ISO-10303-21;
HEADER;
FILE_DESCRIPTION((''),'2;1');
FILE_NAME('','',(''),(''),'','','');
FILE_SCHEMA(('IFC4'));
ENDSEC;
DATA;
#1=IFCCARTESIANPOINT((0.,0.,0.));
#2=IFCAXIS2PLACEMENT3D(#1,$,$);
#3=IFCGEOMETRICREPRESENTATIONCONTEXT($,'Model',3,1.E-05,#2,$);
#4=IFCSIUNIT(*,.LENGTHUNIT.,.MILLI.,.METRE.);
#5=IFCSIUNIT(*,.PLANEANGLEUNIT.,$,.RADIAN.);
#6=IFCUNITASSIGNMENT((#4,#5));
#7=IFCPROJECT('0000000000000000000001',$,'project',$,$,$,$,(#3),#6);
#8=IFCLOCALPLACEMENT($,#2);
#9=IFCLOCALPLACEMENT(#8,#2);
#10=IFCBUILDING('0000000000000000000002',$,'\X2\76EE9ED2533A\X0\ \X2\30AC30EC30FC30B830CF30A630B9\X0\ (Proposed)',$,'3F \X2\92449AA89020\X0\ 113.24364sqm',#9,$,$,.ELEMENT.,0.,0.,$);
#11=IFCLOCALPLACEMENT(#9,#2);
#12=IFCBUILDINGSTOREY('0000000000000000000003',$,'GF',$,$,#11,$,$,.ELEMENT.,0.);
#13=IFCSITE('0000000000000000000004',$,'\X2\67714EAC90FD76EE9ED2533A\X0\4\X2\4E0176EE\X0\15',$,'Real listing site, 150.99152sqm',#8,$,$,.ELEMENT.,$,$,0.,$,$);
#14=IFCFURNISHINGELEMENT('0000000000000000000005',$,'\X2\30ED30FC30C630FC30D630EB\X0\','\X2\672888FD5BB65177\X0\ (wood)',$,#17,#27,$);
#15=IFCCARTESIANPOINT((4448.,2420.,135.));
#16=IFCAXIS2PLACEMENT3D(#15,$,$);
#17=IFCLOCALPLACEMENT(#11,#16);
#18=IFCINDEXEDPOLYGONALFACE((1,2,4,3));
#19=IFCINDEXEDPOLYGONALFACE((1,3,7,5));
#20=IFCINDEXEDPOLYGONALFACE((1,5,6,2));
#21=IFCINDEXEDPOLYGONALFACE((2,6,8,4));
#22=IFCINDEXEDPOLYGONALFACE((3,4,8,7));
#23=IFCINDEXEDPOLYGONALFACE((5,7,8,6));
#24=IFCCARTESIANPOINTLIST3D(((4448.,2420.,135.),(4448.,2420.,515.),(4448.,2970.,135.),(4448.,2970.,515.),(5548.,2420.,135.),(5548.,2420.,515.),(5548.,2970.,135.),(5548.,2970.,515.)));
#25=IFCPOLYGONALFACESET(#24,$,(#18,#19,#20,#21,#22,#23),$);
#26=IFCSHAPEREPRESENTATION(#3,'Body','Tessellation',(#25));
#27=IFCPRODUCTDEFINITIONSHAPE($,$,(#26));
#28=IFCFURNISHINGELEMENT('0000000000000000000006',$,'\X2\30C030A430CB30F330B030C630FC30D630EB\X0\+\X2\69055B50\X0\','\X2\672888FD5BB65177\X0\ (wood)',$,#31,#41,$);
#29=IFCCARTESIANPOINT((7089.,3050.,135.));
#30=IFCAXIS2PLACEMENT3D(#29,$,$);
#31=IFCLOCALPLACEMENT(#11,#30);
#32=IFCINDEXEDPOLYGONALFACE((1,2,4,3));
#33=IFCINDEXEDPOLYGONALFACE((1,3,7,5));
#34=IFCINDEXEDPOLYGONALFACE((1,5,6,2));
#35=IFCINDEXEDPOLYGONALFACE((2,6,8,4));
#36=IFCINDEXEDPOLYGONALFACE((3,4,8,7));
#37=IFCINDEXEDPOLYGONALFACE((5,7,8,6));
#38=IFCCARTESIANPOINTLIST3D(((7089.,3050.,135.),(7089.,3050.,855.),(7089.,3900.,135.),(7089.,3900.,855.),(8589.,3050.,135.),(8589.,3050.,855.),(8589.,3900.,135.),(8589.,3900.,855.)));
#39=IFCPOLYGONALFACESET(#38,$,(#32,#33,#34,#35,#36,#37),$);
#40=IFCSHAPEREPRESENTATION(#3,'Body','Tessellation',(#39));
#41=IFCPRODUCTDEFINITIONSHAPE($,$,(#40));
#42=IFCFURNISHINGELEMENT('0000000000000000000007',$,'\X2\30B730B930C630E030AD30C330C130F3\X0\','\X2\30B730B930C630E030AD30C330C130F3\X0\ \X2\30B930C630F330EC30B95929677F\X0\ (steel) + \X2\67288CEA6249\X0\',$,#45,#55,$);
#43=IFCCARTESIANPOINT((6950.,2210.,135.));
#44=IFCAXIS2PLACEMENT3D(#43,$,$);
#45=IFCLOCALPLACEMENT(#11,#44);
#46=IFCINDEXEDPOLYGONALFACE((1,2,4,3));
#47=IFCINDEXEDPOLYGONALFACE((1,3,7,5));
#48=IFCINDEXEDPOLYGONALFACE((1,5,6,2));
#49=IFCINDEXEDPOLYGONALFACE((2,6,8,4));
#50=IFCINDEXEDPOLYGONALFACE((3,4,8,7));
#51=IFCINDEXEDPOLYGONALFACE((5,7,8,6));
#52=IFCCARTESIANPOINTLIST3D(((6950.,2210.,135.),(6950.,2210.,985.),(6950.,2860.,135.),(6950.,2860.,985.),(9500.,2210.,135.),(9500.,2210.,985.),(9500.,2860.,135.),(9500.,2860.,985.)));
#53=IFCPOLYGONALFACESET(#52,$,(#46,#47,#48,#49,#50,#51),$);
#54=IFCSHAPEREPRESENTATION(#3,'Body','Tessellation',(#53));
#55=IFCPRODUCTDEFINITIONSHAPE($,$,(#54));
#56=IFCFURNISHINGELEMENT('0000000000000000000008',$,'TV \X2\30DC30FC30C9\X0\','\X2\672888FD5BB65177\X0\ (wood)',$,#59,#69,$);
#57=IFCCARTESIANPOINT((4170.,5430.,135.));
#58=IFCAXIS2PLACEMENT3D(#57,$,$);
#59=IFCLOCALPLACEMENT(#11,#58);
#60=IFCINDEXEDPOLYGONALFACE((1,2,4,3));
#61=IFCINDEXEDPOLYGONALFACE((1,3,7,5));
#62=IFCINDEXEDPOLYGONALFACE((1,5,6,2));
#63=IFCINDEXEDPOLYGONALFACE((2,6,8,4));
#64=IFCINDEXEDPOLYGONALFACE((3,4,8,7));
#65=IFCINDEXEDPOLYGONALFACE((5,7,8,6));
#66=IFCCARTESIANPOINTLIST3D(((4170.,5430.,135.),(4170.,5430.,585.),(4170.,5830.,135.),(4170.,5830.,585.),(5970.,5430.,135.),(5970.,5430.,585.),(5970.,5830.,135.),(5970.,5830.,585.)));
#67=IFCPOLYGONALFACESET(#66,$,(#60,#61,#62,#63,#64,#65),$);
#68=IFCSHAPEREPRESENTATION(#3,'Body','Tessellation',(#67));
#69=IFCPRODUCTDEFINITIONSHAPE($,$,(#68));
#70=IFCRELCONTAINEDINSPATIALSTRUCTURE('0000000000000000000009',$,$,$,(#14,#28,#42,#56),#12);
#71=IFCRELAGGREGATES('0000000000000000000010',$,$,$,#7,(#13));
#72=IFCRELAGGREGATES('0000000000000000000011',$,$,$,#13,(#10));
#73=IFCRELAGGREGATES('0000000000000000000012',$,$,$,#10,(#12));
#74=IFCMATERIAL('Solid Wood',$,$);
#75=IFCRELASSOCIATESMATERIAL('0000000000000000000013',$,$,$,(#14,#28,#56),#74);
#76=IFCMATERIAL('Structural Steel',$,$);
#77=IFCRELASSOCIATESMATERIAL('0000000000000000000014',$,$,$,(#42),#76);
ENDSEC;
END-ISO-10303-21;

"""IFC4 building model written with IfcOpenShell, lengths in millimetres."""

from ifc_helpers import new_model, si_unit, frame, frame_2d, origin, place, context, project, spatial, rectangle, extrude, material, element, save


model = new_model("IFC4")

# Units and contexts
model_context = context("Model", 3, precision=1e-05, world=origin())
ifc_project = project(units=[si_unit("LENGTHUNIT", "METRE", prefix="MILLI"), si_unit("PLANEANGLEUNIT", "RADIAN")], contexts=[model_context])

# Site, building, storey
site_placement = place(None, origin())
site = spatial("IfcSite", under=ifc_project, at=site_placement, Name="東京都目黒区4丁目15", ObjectType="Real listing site, 150.99152sqm", CompositionType="ELEMENT", RefElevation=0.0)
building_placement = place(site_placement, origin())
building = spatial("IfcBuilding", under=site, at=building_placement, Name="目黒区 ガレージハウス (Proposed)", ObjectType="3F 鉄骨造 113.24364sqm", CompositionType="ELEMENT", ElevationOfRefHeight=0.0, ElevationOfTerrain=0.0)
storey_placement = place(building_placement, origin())
storey = spatial("IfcBuildingStorey", under=building, at=storey_placement, Name="GF", CompositionType="ELEMENT", Elevation=0.0)

# Shared definitions
ifc_material_1 = material(Name="Solid Wood")

# Furnishing elements
furnishing_1_placement = place(storey_placement, frame((4448.0, 2420.0, 135.0)))
element("IfcFurnishingElement", 1, at=furnishing_1_placement, inside=storey, material=ifc_material_1, Name="ローテーブル", Description="木製家具 (wood)", context=model_context, shape_type="SweptSolid", body=[
    extrude(rectangle(XDim=1100.0, YDim=550.0, at=frame_2d((550.0, 275.0))), frame((4448.0, 2420.0, 135.0)), (0.0, 0.0, 1.0), 380.0),
])
furnishing_2_placement = place(storey_placement, frame((7089.0, 3050.0, 135.0)))
element("IfcFurnishingElement", 2, at=furnishing_2_placement, inside=storey, material=ifc_material_1, Name="ダイニングテーブル+椅子", Description="木製家具 (wood)", context=model_context, shape_type="SweptSolid", body=[
    extrude(rectangle(XDim=1500.0, YDim=850.0, at=frame_2d((750.0, 425.0))), frame((7089.0, 3050.0, 135.0)), (0.0, 0.0, 1.0), 720.0),
])
ifc_material_2 = material(Name="Structural Steel")
furnishing_3_placement = place(storey_placement, frame((6950.0, 2210.0, 135.0)))
element("IfcFurnishingElement", 3, at=furnishing_3_placement, inside=storey, material=ifc_material_2, Name="システムキッチン", Description="システムキッチン ステンレス天板 (steel) + 木質扉", context=model_context, shape_type="SweptSolid", body=[
    extrude(rectangle(XDim=2550.0, YDim=650.0, at=frame_2d((1275.0, 325.0))), frame((6950.0, 2210.0, 135.0)), (0.0, 0.0, 1.0), 850.0),
])
furnishing_4_placement = place(storey_placement, frame((4170.0, 5430.0, 135.0)))
element("IfcFurnishingElement", 4, at=furnishing_4_placement, inside=storey, material=ifc_material_1, Name="TV ボード", Description="木製家具 (wood)", context=model_context, shape_type="SweptSolid", body=[
    extrude(rectangle(XDim=1800.0, YDim=400.0, at=frame_2d((900.0, 200.0))), frame((4170.0, 5430.0, 135.0)), (0.0, 0.0, 1.0), 450.0),
])

save(model, "model.ifc")
